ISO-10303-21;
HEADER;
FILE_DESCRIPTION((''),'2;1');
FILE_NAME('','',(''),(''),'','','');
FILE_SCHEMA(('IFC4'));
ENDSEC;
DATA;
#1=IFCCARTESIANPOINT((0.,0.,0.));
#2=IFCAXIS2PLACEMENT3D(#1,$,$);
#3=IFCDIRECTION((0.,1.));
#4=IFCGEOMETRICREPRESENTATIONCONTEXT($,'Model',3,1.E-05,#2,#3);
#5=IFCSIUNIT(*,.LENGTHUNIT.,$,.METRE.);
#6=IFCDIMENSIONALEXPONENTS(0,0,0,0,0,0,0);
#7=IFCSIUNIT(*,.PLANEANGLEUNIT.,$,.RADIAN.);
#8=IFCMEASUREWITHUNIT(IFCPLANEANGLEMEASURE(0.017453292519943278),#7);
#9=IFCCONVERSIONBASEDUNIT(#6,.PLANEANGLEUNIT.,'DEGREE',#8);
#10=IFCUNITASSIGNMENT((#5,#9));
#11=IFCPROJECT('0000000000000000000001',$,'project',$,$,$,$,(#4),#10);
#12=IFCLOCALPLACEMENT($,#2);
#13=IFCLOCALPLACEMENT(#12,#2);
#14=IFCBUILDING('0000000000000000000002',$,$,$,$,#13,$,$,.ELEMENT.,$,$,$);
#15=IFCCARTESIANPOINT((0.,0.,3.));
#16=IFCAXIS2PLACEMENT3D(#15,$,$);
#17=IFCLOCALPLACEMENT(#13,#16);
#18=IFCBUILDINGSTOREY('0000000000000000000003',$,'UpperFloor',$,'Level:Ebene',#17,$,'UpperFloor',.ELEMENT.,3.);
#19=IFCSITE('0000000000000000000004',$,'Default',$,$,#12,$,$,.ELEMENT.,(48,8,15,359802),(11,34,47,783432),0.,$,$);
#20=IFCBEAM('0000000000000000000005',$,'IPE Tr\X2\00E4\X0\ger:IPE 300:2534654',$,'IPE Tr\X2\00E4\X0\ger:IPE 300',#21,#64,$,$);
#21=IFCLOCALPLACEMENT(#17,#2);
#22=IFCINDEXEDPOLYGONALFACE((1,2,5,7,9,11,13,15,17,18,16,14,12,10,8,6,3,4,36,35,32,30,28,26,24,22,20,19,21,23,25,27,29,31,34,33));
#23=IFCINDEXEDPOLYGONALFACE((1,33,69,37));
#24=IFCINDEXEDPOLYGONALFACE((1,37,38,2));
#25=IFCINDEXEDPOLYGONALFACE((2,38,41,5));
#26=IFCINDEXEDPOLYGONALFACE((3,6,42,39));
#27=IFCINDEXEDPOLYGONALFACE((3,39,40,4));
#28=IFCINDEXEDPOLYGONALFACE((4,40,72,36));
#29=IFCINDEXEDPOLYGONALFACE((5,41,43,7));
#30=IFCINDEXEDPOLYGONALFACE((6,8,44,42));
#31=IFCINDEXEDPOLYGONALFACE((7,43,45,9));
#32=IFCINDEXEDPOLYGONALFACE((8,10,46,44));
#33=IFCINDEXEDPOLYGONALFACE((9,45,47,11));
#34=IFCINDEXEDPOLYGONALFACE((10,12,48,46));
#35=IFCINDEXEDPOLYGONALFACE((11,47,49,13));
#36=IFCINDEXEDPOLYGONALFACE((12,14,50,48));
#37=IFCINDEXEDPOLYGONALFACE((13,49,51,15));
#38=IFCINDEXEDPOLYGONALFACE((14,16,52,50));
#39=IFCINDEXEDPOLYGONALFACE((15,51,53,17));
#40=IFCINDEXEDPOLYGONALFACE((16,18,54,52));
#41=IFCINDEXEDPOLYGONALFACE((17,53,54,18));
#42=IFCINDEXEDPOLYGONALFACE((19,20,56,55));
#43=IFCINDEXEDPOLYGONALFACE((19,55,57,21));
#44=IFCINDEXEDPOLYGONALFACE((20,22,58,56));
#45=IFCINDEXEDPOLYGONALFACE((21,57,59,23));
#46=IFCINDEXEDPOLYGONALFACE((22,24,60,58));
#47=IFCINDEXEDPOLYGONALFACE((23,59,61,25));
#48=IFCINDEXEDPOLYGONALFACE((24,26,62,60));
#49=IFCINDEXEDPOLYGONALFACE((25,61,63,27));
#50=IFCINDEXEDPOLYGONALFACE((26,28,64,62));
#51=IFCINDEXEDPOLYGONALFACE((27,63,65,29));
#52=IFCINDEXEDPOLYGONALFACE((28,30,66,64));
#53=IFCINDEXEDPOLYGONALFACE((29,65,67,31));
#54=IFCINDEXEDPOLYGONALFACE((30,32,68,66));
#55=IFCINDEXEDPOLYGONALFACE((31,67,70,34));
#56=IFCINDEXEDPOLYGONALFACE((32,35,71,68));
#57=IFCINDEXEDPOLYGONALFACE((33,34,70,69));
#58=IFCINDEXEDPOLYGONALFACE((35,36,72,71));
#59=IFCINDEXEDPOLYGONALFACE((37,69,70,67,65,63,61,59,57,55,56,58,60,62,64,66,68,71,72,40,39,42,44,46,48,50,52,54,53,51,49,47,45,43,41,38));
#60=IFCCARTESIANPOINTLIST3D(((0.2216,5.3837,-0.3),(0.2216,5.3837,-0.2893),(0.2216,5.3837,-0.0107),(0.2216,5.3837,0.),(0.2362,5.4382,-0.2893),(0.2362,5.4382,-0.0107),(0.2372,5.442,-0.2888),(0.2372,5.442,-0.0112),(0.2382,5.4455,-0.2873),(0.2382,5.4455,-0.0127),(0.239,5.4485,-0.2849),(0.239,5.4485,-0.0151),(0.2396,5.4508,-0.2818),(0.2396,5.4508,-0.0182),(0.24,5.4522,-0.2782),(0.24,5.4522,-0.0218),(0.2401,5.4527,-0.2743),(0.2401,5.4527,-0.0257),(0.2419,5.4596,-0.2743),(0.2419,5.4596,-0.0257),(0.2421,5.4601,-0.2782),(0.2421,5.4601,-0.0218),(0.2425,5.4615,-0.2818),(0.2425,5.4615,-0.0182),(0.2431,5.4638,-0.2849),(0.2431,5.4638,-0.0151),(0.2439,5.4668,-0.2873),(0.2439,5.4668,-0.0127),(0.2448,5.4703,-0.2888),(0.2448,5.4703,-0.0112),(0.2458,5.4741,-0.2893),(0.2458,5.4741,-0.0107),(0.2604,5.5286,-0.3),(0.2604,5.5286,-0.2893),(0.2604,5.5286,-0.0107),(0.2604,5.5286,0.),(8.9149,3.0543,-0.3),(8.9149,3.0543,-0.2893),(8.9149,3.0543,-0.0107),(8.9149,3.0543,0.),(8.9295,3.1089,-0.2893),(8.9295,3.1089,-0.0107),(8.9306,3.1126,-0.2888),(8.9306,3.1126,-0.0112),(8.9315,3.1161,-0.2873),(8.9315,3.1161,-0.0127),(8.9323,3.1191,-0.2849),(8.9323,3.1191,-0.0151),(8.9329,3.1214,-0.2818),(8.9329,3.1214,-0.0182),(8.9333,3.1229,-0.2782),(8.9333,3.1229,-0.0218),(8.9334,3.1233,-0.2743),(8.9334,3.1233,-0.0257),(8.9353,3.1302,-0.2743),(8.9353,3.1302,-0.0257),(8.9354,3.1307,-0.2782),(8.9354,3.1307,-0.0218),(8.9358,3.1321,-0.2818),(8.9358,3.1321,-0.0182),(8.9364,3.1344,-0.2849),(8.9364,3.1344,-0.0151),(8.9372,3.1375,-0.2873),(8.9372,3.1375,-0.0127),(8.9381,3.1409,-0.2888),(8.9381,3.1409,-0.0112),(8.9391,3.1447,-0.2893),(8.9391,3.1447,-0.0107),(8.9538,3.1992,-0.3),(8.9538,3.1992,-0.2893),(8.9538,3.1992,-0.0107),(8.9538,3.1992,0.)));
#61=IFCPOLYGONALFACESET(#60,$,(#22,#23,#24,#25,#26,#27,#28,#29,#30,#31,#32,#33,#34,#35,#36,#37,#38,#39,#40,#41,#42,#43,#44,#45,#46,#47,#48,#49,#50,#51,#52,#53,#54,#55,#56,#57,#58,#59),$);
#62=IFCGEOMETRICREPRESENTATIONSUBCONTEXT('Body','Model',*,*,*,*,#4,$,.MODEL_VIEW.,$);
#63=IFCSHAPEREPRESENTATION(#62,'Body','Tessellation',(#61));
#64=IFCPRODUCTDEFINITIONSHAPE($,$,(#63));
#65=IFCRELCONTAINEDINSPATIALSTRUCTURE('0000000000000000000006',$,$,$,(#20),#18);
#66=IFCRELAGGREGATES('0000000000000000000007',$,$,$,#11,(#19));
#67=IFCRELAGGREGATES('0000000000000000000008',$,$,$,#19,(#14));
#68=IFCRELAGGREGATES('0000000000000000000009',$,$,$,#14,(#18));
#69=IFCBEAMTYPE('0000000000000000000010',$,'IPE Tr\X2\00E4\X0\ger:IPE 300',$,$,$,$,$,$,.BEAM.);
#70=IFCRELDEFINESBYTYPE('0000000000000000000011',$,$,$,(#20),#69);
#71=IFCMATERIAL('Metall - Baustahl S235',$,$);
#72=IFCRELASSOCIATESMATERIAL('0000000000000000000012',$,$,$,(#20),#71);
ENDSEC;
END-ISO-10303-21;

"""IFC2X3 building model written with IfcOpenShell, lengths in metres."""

from ifc_helpers import new_model, entity, si_unit, converted_unit, direction, frame, frame_2d, origin, place, context, subcontext, project, spatial, i_section, extrude, material, type_object, element, save


model = new_model("IFC2X3")

# Units and contexts
model_context = context("Model", 3, precision=1e-05, world=origin(), true_north=direction((0.0, 1.0)))
body_context = subcontext(model_context, "Body", "Model", "MODEL_VIEW")
ifc_project = project(units=[si_unit("LENGTHUNIT", "METRE"), converted_unit("PLANEANGLEUNIT", "DEGREE", entity("IfcPlaneAngleMeasure", 0.017453292519943278), si_unit("PLANEANGLEUNIT", "RADIAN"), dimensions=[0, 0, 0, 0, 0, 0, 0])], contexts=[model_context])

# Site, building, storey
site_placement = place(None, origin())
site = spatial("IfcSite", under=ifc_project, at=site_placement, Name="Default", CompositionType="ELEMENT", RefLatitude=(48, 8, 15, 359802), RefLongitude=(11, 34, 47, 783432), RefElevation=0.0)
building_placement = place(site_placement, origin())
building = spatial("IfcBuilding", under=site, at=building_placement, CompositionType="ELEMENT")
storey_placement = place(building_placement, frame((0.0, 0.0, 3.0)))
storey = spatial("IfcBuildingStorey", under=building, at=storey_placement, Name="UpperFloor", ObjectType="Level:Ebene", LongName="UpperFloor", CompositionType="ELEMENT", Elevation=3.0)

# Beam
ifc_material = material(Name="Metall - Baustahl S235")
beam_type = type_object("IfcBeamType", Name="IPE Träger:IPE 300", PredefinedType="BEAM")
beam_placement = place(storey_placement, frame((0.241, 5.4561, 0.0), z_axis=(0.0, 0.0, 1.0), x_axis=(0.965926, -0.258819, 0.0)))
element("IfcBeam", 1, at=beam_placement, inside=storey, type_object=beam_type, material=ifc_material, Name="IPE Träger:IPE 300:2534654", ObjectType="IPE Träger:IPE 300", context=body_context, shape_type="SweptSolid", body=[
    extrude(i_section(OverallWidth=0.15, OverallDepth=0.3, WebThickness=0.0071, FlangeThickness=0.0107, FilletRadius=0.015, at=frame_2d((0.0, 0.0), x_axis=(0.0, 1.0))), frame((0.0, 0.0, -0.15), z_axis=(1.0, 0.0, 0.0), x_axis=(0.0, 0.0, -1.0)), (0.0, 0.0, 1.0), 9.0),
])

save(model, "model.ifc")
